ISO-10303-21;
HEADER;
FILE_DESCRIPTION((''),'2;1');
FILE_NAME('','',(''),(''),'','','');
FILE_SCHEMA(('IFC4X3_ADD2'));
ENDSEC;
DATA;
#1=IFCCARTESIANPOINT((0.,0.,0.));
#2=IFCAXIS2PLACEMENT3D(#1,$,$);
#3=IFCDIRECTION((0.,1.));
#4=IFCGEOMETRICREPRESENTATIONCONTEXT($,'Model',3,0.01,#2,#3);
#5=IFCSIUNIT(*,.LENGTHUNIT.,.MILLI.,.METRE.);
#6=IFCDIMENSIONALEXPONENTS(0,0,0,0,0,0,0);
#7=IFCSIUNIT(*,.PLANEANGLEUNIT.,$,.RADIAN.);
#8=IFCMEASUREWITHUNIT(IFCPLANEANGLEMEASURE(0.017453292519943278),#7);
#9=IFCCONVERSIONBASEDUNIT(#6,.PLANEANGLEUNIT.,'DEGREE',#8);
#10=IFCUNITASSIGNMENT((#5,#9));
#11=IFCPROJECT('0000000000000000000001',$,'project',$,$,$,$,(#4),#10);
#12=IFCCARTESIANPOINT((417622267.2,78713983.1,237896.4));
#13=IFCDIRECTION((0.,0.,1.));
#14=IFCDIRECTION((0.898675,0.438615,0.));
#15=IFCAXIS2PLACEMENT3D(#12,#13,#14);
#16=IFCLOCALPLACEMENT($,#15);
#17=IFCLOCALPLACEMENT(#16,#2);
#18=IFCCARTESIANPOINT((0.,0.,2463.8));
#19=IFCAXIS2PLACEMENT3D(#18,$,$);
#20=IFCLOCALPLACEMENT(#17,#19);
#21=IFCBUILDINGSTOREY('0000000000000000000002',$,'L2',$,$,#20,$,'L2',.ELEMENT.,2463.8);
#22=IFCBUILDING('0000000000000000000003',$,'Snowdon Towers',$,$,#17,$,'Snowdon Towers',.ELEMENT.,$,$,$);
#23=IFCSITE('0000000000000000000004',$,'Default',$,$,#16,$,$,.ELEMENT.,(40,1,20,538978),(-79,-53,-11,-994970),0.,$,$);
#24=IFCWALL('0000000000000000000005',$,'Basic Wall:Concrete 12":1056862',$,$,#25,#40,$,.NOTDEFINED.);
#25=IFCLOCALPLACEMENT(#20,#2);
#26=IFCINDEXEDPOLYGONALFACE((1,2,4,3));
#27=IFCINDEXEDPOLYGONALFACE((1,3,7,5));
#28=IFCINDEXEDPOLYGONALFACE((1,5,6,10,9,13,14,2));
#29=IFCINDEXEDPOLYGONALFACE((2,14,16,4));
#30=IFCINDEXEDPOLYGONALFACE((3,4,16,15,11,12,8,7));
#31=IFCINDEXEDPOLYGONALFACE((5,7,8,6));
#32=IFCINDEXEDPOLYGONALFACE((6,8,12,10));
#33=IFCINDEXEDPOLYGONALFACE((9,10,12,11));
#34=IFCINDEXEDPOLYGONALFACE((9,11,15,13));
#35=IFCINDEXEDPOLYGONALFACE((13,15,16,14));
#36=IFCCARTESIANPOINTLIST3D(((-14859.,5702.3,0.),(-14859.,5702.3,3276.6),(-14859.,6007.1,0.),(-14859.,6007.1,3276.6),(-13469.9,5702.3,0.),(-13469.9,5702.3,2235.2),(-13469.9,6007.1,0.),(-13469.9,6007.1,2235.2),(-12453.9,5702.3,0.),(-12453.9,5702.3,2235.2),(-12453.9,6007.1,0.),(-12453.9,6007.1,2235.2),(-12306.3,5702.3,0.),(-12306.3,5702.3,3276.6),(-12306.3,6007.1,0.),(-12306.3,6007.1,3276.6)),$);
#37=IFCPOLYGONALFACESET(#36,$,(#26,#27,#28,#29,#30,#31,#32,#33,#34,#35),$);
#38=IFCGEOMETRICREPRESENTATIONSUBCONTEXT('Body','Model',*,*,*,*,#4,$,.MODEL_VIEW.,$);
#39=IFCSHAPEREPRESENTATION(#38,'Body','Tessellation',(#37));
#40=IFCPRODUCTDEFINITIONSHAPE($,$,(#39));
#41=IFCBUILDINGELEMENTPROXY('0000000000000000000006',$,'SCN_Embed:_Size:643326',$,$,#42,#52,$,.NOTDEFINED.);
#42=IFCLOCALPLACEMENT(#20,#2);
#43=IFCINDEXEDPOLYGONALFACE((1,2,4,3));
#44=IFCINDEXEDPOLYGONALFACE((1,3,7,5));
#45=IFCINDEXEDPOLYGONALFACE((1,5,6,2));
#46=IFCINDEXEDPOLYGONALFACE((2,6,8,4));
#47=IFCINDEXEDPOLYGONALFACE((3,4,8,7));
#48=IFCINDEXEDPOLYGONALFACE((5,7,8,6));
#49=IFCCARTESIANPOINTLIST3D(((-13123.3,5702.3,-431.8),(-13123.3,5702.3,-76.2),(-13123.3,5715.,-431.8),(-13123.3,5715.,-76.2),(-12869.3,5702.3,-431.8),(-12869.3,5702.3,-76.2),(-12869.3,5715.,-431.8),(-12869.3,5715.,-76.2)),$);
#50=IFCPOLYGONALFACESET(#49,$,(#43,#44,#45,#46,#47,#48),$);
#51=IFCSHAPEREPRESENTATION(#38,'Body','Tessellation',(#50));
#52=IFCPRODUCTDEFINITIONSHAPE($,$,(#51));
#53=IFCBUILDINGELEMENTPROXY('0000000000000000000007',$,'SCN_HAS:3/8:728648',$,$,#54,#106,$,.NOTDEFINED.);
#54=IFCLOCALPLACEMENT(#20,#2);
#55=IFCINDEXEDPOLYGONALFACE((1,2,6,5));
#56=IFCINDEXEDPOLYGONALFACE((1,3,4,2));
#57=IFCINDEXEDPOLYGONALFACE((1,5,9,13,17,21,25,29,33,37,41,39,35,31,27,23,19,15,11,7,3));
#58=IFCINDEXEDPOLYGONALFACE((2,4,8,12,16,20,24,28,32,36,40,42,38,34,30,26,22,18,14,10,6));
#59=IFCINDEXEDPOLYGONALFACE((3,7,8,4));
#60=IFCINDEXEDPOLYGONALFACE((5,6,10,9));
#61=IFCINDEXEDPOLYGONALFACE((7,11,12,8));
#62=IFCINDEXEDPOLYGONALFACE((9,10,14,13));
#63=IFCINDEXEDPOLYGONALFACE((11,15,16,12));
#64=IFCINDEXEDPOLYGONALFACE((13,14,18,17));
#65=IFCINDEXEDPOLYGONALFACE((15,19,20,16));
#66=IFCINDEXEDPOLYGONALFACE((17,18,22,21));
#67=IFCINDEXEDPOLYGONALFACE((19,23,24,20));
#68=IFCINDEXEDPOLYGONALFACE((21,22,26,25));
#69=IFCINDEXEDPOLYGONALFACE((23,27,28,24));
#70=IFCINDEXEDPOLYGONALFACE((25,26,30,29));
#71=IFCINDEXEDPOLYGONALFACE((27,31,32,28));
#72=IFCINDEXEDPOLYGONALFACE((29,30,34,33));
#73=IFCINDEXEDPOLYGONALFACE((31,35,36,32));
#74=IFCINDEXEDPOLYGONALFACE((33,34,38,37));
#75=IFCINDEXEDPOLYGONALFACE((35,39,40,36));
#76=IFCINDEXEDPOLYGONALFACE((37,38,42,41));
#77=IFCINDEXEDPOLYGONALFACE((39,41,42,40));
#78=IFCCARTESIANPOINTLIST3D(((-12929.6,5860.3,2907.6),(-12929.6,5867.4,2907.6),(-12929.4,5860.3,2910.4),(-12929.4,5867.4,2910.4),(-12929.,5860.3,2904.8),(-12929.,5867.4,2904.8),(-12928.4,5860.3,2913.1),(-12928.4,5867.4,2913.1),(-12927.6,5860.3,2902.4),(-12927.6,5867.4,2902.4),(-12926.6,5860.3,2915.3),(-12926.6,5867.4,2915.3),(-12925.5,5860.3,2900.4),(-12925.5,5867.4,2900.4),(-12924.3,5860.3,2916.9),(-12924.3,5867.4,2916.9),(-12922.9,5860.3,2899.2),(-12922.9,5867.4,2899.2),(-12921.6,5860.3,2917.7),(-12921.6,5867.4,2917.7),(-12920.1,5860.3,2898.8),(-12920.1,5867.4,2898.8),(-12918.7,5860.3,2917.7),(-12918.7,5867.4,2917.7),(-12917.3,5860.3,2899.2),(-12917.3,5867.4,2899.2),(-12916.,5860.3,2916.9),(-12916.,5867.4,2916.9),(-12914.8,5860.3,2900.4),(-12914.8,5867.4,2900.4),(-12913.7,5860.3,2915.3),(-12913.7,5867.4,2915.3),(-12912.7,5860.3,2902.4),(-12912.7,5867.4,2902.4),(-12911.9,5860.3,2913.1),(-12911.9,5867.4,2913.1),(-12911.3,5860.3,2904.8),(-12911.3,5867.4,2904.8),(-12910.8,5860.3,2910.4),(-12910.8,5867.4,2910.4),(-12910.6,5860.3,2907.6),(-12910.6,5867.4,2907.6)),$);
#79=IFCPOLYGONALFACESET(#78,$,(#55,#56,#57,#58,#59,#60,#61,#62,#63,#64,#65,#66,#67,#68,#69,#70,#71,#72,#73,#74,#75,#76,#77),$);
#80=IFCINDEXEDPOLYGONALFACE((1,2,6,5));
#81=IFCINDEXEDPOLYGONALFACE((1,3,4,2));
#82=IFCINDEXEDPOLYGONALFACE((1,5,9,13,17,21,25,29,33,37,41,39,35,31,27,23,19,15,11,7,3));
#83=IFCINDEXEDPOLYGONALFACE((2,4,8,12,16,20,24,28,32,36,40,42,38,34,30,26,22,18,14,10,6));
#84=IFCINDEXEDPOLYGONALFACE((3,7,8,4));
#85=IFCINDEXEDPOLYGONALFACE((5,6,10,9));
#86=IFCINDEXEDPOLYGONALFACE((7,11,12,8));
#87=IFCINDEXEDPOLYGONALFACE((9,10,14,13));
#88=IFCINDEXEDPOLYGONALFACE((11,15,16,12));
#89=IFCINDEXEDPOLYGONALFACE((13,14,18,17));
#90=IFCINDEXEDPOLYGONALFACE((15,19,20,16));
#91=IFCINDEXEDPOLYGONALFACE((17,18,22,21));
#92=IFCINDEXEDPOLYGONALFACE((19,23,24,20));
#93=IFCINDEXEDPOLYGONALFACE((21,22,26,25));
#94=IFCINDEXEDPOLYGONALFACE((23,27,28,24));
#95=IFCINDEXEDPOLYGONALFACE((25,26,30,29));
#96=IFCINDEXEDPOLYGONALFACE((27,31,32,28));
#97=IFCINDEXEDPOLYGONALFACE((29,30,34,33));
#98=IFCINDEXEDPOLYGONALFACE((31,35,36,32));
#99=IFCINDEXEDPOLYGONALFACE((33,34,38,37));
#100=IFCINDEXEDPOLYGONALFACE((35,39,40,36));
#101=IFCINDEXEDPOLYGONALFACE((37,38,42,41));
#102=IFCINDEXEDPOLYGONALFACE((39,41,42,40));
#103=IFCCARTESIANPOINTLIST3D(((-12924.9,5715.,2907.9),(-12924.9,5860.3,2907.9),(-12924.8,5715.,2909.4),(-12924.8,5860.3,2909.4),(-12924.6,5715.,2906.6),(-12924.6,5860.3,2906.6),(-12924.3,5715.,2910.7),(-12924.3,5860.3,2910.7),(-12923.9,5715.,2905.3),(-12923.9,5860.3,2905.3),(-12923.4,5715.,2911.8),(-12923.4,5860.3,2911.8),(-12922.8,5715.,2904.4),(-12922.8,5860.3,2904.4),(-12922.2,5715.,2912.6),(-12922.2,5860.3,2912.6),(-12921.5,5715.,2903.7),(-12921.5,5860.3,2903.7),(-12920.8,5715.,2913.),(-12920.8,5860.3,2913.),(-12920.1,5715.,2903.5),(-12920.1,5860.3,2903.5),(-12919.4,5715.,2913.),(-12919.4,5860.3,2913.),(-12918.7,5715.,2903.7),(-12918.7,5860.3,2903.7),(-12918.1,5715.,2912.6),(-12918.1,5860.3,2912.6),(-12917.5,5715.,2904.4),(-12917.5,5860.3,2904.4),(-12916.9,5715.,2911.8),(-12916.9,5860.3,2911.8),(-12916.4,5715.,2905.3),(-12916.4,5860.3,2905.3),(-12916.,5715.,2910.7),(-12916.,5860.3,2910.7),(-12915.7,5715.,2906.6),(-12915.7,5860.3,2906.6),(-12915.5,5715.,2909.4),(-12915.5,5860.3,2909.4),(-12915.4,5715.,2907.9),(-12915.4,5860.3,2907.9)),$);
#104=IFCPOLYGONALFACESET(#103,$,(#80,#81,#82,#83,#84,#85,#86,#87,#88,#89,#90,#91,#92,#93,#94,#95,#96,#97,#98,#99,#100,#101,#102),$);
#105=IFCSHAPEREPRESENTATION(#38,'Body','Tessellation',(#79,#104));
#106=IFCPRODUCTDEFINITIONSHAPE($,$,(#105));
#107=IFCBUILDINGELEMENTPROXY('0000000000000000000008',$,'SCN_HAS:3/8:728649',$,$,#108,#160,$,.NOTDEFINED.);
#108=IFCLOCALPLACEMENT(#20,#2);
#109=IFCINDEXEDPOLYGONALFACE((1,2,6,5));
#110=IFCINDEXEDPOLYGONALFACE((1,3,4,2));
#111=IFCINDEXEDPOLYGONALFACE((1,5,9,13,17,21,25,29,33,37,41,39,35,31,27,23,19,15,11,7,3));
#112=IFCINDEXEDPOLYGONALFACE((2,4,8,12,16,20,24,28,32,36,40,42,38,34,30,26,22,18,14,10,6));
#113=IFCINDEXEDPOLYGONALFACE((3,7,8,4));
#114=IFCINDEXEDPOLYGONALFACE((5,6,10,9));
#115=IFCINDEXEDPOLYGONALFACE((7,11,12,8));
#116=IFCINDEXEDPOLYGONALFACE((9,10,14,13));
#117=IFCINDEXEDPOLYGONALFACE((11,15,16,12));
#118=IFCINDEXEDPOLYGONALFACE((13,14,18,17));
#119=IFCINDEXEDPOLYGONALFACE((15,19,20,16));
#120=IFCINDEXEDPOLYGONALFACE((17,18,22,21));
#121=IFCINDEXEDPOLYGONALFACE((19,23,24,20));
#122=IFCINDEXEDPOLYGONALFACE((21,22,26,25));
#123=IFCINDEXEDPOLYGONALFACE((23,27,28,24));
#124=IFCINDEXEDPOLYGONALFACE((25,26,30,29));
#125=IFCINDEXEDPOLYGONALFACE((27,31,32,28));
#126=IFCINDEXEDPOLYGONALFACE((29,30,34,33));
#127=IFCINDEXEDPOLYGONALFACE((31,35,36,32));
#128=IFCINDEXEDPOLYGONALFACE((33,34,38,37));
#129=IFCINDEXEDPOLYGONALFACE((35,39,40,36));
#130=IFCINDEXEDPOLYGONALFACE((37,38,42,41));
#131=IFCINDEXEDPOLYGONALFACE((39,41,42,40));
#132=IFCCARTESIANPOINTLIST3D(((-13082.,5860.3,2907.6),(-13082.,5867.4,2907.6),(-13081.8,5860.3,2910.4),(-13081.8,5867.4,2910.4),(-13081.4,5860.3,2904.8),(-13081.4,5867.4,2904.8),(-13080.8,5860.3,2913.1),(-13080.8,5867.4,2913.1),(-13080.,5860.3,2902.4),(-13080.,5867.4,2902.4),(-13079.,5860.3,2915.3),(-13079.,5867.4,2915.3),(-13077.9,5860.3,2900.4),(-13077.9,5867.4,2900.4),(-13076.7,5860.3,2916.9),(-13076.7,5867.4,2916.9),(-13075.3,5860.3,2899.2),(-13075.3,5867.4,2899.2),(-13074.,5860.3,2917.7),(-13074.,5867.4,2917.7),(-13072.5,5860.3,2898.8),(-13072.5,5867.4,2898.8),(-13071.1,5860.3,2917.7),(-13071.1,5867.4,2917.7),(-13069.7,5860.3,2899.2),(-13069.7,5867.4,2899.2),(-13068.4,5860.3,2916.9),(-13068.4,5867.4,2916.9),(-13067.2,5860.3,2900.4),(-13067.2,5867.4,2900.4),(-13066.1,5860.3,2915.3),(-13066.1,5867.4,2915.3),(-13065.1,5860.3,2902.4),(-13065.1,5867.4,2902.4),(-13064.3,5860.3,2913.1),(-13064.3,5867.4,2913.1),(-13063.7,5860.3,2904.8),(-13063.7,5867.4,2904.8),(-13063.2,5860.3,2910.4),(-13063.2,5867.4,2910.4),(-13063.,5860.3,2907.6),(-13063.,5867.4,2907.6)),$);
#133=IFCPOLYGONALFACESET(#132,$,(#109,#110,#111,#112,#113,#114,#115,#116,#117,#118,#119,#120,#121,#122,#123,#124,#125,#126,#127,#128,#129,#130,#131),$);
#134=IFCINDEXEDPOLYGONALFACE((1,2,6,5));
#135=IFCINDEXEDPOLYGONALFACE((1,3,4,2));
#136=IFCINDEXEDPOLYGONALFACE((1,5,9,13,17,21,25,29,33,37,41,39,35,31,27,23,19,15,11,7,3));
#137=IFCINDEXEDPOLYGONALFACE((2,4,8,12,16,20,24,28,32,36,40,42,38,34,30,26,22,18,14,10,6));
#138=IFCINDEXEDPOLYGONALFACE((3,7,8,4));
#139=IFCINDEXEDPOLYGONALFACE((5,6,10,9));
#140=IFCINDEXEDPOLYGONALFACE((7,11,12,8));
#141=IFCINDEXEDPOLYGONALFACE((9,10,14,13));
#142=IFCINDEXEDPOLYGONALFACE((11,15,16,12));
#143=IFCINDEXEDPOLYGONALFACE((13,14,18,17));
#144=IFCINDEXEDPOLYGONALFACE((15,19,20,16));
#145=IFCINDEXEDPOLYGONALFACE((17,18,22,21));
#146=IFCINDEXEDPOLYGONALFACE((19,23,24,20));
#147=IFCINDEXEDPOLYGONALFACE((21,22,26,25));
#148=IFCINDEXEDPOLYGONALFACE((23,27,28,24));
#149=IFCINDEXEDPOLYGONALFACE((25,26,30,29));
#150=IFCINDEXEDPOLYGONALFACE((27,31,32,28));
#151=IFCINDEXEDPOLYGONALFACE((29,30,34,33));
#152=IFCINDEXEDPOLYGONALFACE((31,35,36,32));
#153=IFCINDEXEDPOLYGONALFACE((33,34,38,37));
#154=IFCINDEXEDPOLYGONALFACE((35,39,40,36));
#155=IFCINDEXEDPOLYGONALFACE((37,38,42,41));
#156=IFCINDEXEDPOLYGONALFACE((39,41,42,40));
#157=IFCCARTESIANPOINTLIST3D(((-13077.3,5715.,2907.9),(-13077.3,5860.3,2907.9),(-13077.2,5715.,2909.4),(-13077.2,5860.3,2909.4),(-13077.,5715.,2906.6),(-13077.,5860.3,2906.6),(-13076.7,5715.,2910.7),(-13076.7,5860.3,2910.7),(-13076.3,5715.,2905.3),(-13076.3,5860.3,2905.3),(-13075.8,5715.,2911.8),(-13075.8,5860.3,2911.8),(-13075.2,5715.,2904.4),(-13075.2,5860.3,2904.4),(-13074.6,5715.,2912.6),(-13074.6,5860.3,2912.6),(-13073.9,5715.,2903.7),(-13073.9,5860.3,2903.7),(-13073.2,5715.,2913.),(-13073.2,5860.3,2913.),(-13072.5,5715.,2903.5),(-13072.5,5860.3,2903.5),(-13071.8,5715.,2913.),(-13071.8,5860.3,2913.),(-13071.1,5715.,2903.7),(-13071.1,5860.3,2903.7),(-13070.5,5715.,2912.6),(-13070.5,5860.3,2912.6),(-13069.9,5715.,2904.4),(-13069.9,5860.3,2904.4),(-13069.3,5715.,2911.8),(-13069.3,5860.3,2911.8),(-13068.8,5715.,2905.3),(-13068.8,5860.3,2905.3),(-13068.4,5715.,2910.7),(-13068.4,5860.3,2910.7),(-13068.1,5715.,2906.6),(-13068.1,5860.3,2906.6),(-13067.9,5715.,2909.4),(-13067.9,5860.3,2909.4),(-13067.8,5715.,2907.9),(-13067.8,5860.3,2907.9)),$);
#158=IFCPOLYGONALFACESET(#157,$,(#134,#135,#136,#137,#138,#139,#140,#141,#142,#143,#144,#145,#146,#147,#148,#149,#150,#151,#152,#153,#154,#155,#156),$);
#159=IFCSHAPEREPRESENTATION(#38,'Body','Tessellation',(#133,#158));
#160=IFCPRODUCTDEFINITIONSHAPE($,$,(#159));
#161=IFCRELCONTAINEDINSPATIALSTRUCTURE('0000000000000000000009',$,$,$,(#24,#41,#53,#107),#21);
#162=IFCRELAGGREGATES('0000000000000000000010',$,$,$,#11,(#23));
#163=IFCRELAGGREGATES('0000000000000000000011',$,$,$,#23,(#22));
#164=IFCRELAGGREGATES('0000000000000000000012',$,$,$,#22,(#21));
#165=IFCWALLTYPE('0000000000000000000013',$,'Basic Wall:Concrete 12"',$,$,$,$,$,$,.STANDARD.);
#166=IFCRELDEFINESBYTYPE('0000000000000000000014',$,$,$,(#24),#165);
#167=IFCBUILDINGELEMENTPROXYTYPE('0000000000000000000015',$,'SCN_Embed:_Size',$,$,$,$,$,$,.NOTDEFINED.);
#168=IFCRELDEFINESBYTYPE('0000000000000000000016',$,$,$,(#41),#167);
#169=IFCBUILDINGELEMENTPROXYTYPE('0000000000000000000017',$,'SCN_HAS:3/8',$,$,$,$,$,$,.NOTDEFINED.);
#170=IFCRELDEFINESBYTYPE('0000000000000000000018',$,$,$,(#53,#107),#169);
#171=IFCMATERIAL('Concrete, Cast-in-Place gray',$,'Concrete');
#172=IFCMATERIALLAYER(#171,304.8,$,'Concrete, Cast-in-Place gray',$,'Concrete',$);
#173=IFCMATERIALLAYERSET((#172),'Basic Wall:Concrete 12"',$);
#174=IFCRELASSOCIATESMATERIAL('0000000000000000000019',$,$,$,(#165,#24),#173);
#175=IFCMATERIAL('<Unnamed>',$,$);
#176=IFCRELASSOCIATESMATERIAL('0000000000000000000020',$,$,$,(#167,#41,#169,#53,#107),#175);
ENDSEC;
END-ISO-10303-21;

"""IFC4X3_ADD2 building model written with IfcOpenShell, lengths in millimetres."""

from ifc_helpers import new_model, entity, si_unit, converted_unit, direction, frame, frame_2d, origin, place, context, subcontext, project, spatial, rectangle, circle, extrude, source, transform, mapped, material, layer, layer_set, type_object, type_shapes, element, save


model = new_model("IFC4X3_ADD2")

# Units and contexts
model_context = context("Model", 3, precision=0.01, world=origin(), true_north=direction((0.0, 1.0)))
body_context = subcontext(model_context, "Body", "Model", "MODEL_VIEW")
ifc_project = project(units=[si_unit("LENGTHUNIT", "METRE", prefix="MILLI"), converted_unit("PLANEANGLEUNIT", "DEGREE", entity("IfcPlaneAngleMeasure", 0.017453292519943278), si_unit("PLANEANGLEUNIT", "RADIAN"), dimensions=[0, 0, 0, 0, 0, 0, 0])], contexts=[model_context])

# Site, building, storey
site_placement = place(None, frame((417622267.2, 78713983.1, 237896.4), z_axis=(0.0, 0.0, 1.0), x_axis=(0.898675, 0.438615, 0.0)))
site = spatial("IfcSite", under=ifc_project, at=site_placement, Name="Default", CompositionType="ELEMENT", RefLatitude=(40, 1, 20, 538978), RefLongitude=(-79, -53, -11, -994970), RefElevation=0.0)
building_placement = place(site_placement, origin())
building = spatial("IfcBuilding", under=site, at=building_placement, Name="Snowdon Towers", LongName="Snowdon Towers", CompositionType="ELEMENT")
storey_placement = place(building_placement, frame((0.0, 0.0, 2463.8)))
storey = spatial("IfcBuildingStorey", under=building, at=storey_placement, Name="L2", LongName="L2", CompositionType="ELEMENT", Elevation=2463.8)

# Shared definitions
ifc_material_1 = material(Name="Concrete, Cast-in-Place gray", Category="Concrete")

# Wall, opening
ifc_layer_1 = layer(ifc_material_1, 304.8, Name="Concrete, Cast-in-Place gray", Category="Concrete")
ifc_layer_set_1 = layer_set([ifc_layer_1], Name="Basic Wall:Concrete 12\"")
wall_type = type_object("IfcWallType", Name="Basic Wall:Concrete 12\"", PredefinedType="STANDARD", material=ifc_layer_set_1)
wall_placement = place(storey_placement, frame((-12306.3, 5854.7, 0.0), z_axis=(0.0, 0.0, 1.0), x_axis=(-1.0, 0.0, 0.0)))
wall = element("IfcWall", 1, at=wall_placement, inside=storey, type_object=wall_type, material=ifc_layer_set_1, Name="Basic Wall:Concrete 12\":1056862", PredefinedType="NOTDEFINED", context=body_context, shape_type="SweptSolid", body=[
    extrude(rectangle(XDim=2552.7, YDim=304.8, at=frame_2d((1276.3, 0.0), x_axis=(-1.0, 0.0))), origin(), (0.0, 0.0, 1.0), 3276.6),
])
opening_1_placement = place(wall_placement, origin())
element("IfcOpeningElement", 2, at=opening_1_placement, cuts=wall, PredefinedType="OPENING", context=body_context, shape_type="SweptSolid", body=[
    extrude(rectangle(XDim=2235.2, YDim=1016.0, at=frame_2d((0.0, 0.0), x_axis=(0.0, 1.0))), frame((655.6, 152.4, 1117.6), z_axis=(0.0, -1.0, 0.0), x_axis=(1.0, 0.0, 0.0)), (0.0, 0.0, 1.0), 304.8),
])

# Building element proxies
ifc_material_2 = material(Name="<Unnamed>")
building_element_proxy_type_1 = type_object("IfcBuildingElementProxyType", Name="SCN_Embed:_Size", PredefinedType="NOTDEFINED", material=ifc_material_2)
shared_shape_1 = source(origin(), body_context, "Body", "SweptSolid", [
    extrude(rectangle(XDim=254.0, YDim=355.6, at=frame_2d((0.0, 0.0), x_axis=(1.0, 0.0))), frame((0.0, 0.0, -12.7), z_axis=(0.0, 0.0, 1.0), x_axis=(-1.0, 0.0, 0.0)), (0.0, 0.0, 1.0), 12.7),
])
type_shapes(building_element_proxy_type_1, [shared_shape_1])
proxy_placement = place(storey_placement, frame((-12996.3, 5702.3, -254.0), z_axis=(0.0, -1.0, 0.0), x_axis=(1.0, 0.0, 0.0)))
element("IfcBuildingElementProxy", 3, at=proxy_placement, inside=storey, type_object=building_element_proxy_type_1, material=ifc_material_2, Name="SCN_Embed:_Size:643326", PredefinedType="NOTDEFINED", context=body_context, shape_type="MappedRepresentation", body=[
    mapped(shared_shape_1, transform((0.0, 0.0, 0.0), scale=1.0)),
])
building_element_proxy_type_2 = type_object("IfcBuildingElementProxyType", Name="SCN_HAS:3/8", PredefinedType="NOTDEFINED", material=ifc_material_2)
shared_shape_2 = source(origin(), body_context, "Body", "SweptSolid", [
    extrude(circle(Radius=9.5, at=frame_2d((0.0, 0.0), x_axis=(1.0, 0.0))), frame((0.0, 0.0, -152.4), z_axis=(0.0, 0.0, 1.0), x_axis=(0.0, -1.0, 0.0)), (0.0, 0.0, 1.0), 7.1),
    extrude(circle(Radius=4.8, at=frame_2d((0.0, 0.0), x_axis=(1.0, 0.0))), frame((0.0, 0.0, -145.3), z_axis=(0.0, 0.0, 1.0), x_axis=(0.0, -1.0, 0.0)), (0.0, 0.0, 1.0), 145.3),
])
type_shapes(building_element_proxy_type_2, [shared_shape_2])
for number, where, z_axis, x_axis, name in (
    (4, (-12920.1, 5715.0, 2908.3), (0.0, -1.0, 0.0), (1.0, 0.0, 0.0), "SCN_HAS:3/8:728648"),
    (5, (-13072.5, 5715.0, 2908.3), (0.0, -1.0, 0.0), (1.0, 0.0, 0.0), "SCN_HAS:3/8:728649"),
):
    element("IfcBuildingElementProxy", number, at=place(storey_placement, frame(where, z_axis=z_axis, x_axis=x_axis)), inside=storey, type_object=building_element_proxy_type_2, material=ifc_material_2, Name=name, PredefinedType="NOTDEFINED", context=body_context, shape_type="MappedRepresentation", body=[
        mapped(shared_shape_2, transform((0.0, 0.0, 0.0), scale=1.0)),
    ])

save(model, "model.ifc")
